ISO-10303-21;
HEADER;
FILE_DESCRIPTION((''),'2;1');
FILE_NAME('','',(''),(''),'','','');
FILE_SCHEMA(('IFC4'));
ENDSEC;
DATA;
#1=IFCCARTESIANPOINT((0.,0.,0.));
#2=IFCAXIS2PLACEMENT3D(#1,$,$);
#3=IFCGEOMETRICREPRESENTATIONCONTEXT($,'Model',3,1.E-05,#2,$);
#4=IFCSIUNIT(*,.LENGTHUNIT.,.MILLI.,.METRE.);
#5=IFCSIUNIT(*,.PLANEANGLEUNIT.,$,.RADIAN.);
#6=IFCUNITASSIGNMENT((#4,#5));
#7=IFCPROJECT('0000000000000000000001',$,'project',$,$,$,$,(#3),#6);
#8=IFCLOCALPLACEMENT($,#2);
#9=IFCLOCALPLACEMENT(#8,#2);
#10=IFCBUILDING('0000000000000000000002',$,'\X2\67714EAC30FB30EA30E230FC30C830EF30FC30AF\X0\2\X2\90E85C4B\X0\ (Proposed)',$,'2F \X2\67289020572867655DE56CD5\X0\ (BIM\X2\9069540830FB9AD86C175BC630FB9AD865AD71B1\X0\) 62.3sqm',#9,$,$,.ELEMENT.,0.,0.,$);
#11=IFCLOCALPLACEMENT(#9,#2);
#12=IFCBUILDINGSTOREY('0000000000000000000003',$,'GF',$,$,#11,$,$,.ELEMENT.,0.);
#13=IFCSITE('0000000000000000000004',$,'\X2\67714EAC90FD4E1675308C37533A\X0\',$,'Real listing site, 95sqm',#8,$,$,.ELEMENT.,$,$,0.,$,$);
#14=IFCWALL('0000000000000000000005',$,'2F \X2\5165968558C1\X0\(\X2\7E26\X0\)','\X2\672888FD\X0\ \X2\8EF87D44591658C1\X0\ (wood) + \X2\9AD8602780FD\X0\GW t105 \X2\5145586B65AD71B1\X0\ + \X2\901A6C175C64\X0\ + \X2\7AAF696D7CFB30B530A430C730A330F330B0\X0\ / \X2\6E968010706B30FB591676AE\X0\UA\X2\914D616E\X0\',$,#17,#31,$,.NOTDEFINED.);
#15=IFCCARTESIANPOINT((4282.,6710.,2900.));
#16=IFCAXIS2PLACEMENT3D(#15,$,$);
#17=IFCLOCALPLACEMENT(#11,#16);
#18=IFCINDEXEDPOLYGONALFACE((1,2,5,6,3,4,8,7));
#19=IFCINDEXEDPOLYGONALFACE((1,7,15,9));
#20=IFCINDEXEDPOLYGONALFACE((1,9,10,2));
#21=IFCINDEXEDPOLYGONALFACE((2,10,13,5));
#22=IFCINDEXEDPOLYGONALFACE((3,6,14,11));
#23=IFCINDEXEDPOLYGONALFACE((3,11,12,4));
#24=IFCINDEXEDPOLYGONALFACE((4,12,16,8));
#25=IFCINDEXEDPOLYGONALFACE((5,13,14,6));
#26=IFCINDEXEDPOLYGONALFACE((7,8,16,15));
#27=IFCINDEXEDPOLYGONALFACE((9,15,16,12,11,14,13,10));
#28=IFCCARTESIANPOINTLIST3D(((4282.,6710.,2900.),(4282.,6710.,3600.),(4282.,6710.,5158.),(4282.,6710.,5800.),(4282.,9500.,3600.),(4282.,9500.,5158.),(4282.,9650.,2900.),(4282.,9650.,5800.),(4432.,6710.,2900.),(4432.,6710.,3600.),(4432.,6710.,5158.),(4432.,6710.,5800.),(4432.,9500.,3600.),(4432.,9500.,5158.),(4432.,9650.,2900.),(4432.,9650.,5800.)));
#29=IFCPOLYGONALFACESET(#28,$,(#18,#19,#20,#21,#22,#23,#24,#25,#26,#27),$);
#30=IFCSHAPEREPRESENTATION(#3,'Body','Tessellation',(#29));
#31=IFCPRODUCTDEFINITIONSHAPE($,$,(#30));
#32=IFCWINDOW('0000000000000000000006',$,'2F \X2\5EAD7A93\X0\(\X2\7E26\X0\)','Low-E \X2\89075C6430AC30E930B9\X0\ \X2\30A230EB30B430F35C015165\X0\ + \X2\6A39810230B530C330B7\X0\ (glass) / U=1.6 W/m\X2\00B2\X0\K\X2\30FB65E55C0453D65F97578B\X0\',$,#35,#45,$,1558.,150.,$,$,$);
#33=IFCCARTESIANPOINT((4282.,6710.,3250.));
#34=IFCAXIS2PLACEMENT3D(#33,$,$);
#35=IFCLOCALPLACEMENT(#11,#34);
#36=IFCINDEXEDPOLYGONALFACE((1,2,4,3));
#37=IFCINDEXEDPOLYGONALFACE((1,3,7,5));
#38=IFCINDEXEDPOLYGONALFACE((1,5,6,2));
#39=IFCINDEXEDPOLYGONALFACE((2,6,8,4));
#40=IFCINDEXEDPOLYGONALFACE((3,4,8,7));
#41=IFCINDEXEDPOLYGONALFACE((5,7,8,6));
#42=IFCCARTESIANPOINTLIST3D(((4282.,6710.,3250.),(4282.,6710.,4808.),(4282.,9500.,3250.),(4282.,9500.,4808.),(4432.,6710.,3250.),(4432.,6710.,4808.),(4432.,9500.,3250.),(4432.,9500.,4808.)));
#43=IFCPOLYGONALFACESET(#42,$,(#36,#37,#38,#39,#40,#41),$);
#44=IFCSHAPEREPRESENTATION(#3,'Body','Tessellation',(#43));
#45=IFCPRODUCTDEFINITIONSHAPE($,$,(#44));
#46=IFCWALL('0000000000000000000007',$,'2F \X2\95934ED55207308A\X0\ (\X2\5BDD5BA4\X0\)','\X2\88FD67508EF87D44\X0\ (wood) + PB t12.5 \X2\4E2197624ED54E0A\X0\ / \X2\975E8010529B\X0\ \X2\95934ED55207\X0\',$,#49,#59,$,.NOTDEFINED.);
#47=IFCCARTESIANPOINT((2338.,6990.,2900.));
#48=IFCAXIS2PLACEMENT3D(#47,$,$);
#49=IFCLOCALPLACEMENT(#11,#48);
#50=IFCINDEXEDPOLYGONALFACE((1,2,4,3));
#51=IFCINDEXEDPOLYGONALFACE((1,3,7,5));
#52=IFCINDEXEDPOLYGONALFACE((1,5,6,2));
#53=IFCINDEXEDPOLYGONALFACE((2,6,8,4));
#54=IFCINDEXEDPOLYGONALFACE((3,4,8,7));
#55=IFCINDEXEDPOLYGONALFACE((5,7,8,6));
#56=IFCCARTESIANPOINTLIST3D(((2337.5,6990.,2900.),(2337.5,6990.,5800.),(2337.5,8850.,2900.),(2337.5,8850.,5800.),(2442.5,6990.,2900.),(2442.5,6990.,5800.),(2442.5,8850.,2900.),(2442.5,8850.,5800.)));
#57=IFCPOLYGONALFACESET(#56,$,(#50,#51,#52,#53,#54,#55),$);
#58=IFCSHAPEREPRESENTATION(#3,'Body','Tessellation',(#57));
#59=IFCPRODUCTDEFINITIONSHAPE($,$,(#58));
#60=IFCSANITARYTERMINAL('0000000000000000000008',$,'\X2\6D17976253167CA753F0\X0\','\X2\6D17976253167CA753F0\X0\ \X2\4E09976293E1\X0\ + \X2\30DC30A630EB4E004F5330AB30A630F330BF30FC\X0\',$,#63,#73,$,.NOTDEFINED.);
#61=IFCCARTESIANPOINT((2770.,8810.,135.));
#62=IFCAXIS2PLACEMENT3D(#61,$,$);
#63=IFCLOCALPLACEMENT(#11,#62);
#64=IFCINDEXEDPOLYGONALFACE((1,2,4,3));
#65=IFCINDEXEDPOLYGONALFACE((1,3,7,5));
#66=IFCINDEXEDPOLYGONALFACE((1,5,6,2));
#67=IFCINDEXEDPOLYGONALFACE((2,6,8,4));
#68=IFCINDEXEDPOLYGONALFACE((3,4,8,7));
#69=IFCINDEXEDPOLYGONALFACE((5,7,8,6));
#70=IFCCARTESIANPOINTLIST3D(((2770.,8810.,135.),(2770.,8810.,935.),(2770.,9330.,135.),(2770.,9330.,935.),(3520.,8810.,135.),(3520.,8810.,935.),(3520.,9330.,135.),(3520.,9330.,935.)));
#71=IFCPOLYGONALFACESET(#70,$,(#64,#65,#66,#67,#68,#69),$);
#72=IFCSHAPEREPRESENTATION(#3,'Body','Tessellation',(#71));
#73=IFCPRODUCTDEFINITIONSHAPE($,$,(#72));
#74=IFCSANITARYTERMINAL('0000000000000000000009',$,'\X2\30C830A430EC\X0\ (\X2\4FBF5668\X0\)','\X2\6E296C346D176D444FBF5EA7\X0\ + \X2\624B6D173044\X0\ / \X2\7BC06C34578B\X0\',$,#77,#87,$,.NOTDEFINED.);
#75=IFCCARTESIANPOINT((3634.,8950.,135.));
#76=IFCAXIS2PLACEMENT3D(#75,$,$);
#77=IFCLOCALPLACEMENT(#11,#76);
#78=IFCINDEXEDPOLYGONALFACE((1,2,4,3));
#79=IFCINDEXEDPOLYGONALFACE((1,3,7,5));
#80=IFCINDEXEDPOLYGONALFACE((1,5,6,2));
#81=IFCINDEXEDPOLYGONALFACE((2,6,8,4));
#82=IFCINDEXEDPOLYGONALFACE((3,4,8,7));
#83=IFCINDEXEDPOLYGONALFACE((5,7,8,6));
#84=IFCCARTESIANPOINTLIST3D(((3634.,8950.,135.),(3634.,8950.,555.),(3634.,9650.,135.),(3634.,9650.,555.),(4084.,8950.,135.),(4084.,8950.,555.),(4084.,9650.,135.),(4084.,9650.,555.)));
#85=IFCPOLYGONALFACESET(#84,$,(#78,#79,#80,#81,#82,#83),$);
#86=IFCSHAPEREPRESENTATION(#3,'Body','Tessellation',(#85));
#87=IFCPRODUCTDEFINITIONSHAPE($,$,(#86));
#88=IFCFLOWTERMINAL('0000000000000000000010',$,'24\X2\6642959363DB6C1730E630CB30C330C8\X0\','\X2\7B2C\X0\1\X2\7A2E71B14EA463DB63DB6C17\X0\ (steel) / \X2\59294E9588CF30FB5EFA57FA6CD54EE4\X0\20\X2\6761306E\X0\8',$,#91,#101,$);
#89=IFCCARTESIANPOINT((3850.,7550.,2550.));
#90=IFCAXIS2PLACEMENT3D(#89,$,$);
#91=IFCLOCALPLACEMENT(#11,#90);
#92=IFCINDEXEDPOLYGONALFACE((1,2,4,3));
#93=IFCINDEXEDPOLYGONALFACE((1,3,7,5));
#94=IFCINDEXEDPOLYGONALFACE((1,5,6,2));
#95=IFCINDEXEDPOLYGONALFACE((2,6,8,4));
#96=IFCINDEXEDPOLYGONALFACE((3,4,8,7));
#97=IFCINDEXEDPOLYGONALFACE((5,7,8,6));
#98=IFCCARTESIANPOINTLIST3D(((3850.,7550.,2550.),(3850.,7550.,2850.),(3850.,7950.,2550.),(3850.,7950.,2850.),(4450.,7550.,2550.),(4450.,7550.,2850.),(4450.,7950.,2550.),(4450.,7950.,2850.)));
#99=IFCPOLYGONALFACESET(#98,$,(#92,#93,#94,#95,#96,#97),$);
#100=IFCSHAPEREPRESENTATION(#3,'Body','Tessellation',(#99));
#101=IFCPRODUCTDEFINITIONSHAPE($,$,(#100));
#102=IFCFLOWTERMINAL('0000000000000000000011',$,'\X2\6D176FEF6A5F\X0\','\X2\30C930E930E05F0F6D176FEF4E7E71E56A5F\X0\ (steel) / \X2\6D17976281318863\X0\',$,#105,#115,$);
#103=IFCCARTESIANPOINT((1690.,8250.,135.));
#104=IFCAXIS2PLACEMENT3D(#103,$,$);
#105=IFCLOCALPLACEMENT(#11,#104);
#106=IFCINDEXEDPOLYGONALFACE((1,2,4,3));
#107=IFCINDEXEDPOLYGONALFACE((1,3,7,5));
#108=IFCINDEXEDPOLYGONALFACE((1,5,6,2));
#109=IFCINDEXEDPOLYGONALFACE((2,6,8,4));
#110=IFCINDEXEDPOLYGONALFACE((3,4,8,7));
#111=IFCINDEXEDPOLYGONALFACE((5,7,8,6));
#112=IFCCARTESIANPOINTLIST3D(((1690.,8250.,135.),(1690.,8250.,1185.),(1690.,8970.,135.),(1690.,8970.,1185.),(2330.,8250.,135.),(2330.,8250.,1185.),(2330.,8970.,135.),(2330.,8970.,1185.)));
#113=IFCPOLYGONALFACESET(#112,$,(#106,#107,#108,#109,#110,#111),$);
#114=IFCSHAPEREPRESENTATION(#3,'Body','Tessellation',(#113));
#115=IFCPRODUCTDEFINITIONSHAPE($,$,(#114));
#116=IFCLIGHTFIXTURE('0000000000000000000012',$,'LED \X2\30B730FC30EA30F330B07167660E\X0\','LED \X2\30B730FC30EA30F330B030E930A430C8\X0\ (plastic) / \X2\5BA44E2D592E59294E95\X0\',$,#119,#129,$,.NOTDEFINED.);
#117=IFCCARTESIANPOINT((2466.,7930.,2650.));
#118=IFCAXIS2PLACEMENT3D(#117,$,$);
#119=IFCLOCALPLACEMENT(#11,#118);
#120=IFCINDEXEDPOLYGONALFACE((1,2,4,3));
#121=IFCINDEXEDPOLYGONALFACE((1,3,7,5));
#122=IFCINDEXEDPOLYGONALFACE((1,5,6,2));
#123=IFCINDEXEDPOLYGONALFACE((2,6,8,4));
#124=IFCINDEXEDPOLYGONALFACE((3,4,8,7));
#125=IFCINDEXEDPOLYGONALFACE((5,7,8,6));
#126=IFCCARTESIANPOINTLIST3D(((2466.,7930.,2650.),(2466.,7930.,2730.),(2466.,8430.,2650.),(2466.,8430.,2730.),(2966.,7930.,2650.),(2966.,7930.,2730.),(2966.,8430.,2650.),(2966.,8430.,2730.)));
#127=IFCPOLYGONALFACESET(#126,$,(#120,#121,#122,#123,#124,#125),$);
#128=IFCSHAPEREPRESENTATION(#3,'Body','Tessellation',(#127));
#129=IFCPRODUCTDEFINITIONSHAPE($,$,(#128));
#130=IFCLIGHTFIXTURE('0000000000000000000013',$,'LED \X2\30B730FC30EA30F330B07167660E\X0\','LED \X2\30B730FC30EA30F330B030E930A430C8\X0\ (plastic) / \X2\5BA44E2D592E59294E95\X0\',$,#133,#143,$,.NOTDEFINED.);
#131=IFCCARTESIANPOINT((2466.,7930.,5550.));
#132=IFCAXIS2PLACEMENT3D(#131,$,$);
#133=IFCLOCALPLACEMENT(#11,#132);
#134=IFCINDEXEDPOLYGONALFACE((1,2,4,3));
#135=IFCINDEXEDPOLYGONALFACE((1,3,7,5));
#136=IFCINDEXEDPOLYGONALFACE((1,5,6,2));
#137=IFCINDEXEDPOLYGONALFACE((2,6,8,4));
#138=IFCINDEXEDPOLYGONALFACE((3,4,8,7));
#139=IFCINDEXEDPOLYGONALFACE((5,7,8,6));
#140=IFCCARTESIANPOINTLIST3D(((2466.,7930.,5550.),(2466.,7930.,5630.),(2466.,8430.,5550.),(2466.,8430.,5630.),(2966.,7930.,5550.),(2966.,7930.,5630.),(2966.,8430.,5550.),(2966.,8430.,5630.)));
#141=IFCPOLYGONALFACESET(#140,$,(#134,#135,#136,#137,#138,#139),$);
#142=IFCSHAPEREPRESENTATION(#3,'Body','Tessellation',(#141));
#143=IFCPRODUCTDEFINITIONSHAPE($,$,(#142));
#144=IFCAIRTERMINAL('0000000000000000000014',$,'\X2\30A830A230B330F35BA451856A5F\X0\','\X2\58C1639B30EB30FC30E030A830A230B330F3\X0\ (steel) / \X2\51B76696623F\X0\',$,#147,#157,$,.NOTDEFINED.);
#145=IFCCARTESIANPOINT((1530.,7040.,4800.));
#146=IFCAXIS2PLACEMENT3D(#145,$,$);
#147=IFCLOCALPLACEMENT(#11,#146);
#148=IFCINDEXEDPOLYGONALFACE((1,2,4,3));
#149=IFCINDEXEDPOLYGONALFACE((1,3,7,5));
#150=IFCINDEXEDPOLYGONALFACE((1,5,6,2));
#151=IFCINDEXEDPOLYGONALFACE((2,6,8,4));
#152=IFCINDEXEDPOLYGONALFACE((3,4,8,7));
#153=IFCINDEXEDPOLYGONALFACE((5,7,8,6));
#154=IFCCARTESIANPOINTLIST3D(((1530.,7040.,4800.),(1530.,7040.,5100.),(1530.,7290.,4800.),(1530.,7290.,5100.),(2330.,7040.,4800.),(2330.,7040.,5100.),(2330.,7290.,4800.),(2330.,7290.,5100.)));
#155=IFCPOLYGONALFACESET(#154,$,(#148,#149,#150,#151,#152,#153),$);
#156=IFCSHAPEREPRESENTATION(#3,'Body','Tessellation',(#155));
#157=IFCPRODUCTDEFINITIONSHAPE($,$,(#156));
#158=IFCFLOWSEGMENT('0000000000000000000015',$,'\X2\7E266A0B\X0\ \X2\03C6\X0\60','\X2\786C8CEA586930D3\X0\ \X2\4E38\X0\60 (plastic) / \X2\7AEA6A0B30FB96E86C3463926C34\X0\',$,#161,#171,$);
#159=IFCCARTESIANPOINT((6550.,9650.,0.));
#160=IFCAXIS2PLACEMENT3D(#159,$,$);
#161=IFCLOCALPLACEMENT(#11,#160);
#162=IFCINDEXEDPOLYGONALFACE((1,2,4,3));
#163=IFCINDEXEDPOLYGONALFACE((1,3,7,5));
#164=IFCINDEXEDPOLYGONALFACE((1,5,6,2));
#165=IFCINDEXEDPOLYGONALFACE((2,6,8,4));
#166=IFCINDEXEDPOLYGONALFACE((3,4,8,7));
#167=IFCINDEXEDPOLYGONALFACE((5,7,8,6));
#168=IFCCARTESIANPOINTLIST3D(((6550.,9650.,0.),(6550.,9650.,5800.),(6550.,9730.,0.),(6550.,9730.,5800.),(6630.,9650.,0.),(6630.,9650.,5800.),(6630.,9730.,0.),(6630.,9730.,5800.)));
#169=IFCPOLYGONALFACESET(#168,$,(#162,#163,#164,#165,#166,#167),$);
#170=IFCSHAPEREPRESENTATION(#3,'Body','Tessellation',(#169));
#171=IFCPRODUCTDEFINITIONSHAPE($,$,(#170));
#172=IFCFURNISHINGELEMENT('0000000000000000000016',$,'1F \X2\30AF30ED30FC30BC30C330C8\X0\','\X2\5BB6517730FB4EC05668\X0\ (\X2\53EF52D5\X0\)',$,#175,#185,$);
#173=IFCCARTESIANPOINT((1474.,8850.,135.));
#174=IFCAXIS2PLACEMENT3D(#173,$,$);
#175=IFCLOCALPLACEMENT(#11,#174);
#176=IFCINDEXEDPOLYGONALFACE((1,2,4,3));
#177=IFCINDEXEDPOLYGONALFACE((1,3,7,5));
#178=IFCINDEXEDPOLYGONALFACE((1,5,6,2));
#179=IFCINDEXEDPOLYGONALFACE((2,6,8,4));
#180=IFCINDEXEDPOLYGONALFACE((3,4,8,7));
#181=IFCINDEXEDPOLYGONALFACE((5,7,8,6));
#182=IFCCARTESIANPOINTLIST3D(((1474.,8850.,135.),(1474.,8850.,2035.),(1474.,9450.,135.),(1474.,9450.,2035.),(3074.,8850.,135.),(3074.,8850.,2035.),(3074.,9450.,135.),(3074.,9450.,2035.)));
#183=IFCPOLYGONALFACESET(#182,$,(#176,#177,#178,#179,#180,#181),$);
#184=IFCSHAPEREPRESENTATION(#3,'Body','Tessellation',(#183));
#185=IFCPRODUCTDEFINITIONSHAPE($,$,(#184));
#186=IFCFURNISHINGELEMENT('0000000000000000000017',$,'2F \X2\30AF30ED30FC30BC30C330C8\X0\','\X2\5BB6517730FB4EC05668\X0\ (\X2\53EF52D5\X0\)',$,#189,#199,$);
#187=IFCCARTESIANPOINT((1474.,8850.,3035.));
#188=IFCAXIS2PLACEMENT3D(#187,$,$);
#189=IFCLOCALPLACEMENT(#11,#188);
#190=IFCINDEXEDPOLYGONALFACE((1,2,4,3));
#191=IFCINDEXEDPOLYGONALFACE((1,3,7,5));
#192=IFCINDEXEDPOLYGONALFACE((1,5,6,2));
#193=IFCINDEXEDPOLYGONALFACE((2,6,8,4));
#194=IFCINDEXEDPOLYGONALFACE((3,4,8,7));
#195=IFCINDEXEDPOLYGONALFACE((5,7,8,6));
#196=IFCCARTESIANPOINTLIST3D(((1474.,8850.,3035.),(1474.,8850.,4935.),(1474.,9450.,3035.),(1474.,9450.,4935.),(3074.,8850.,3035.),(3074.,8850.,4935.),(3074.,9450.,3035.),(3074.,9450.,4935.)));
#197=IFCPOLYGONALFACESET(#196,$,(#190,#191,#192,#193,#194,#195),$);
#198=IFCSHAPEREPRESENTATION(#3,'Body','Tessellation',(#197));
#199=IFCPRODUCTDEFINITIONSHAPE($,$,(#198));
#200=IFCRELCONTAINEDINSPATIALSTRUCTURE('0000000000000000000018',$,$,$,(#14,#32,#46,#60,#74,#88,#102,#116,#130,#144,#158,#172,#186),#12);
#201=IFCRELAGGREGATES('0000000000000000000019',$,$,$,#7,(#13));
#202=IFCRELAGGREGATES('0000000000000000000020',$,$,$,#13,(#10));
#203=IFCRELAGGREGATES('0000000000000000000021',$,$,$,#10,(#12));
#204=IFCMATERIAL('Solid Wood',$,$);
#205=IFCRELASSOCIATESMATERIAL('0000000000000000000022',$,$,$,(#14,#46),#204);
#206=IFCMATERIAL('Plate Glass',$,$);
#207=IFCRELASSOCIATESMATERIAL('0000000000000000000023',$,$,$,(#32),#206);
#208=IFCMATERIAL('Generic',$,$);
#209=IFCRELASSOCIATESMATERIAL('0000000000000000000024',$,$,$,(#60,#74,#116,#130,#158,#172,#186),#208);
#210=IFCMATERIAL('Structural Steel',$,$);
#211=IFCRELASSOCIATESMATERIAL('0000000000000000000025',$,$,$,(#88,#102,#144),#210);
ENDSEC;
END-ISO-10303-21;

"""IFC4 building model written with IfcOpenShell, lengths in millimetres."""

from ifc_helpers import new_model, si_unit, frame, frame_2d, origin, place, context, project, spatial, rectangle, extrude, material, element, fill, save


model = new_model("IFC4")

# Units and contexts
model_context = context("Model", 3, precision=1e-05, world=origin())
ifc_project = project(units=[si_unit("LENGTHUNIT", "METRE", prefix="MILLI"), si_unit("PLANEANGLEUNIT", "RADIAN")], contexts=[model_context])

# Site, building, storey
site_placement = place(None, origin())
site = spatial("IfcSite", under=ifc_project, at=site_placement, Name="東京都世田谷区", ObjectType="Real listing site, 95sqm", CompositionType="ELEMENT", RefElevation=0.0)
building_placement = place(site_placement, origin())
building = spatial("IfcBuilding", under=site, at=building_placement, Name="東京・リモートワーク2部屋 (Proposed)", ObjectType="2F 木造在来工法 (BIM適合・高気密・高断熱) 62.3sqm", CompositionType="ELEMENT", ElevationOfRefHeight=0.0, ElevationOfTerrain=0.0)
storey_placement = place(building_placement, origin())
storey = spatial("IfcBuildingStorey", under=building, at=storey_placement, Name="GF", CompositionType="ELEMENT", Elevation=0.0)

# Shared definitions
ifc_material_1 = material(Name="Solid Wood")

# Shared definitions
ifc_material_2 = material(Name="Plate Glass")

# Wall, opening, window
wall_1_placement = place(storey_placement, frame((4282.0, 6710.0, 2900.0)))
wall_1 = element("IfcWall", 1, at=wall_1_placement, inside=storey, material=ifc_material_1, Name="2F 入隅壁(縦)", Description="木製 軸組外壁 (wood) + 高性能GW t105 充填断熱 + 通気層 + 窯業系サイディング / 準耐火・外皮UA配慮", PredefinedType="NOTDEFINED", context=model_context, shape_type="SweptSolid", body=[
    extrude(rectangle(XDim=150.0, YDim=2940.0, at=frame_2d((75.0, 1470.0))), frame((4282.0, 6710.0, 2900.0)), (0.0, 0.0, 1.0), 2900.0),
])
opening_1_placement = place(storey_placement, frame((4282.0, 6710.0, 3250.0)))
opening_1 = element("IfcOpeningElement", 2, at=opening_1_placement, cuts=wall_1, PredefinedType="NOTDEFINED", context=model_context, shape_type="SweptSolid", body=[
    extrude(rectangle(XDim=150.0, YDim=2790.0, at=frame_2d((75.0, 1395.0))), frame((4282.0, 6710.0, 3250.0)), (0.0, 0.0, 1.0), 1558.0),
])
window_1_placement = place(storey_placement, frame((4282.0, 6710.0, 3250.0)))
window_1 = element("IfcWindow", 3, at=window_1_placement, inside=storey, material=ifc_material_2, Name="2F 庭窓(縦)", Description="Low-E 複層ガラス アルゴン封入 + 樹脂サッシ (glass) / U=1.6 W/m²K・日射取得型", OverallHeight=1558.0, OverallWidth=150.0, context=model_context, shape_type="SweptSolid", body=[
    extrude(rectangle(XDim=150.0, YDim=2790.0, at=frame_2d((75.0, 1395.0))), frame((4282.0, 6710.0, 3250.0)), (0.0, 0.0, 1.0), 1558.0),
])
fill(opening_1, window_1)

# Wall
wall_2_placement = place(storey_placement, frame((2338.0, 6990.0, 2900.0)))
element("IfcWall", 4, at=wall_2_placement, inside=storey, material=ifc_material_1, Name="2F 間仕切り (寝室)", Description="製材軸組 (wood) + PB t12.5 両面仕上 / 非耐力 間仕切", PredefinedType="NOTDEFINED", context=model_context, shape_type="SweptSolid", body=[
    extrude(rectangle(XDim=105.0, YDim=1860.0, at=frame_2d((52.0, 930.0))), frame((2338.0, 6990.0, 2900.0)), (0.0, 0.0, 1.0), 2900.0),
])

# Sanitary terminals
ifc_material_3 = material(Name="Generic")
sanitary_terminal_1_placement = place(storey_placement, frame((2770.0, 8810.0, 135.0)))
element("IfcSanitaryTerminal", 5, at=sanitary_terminal_1_placement, inside=storey, material=ifc_material_3, Name="洗面化粧台", Description="洗面化粧台 三面鏡 + ボウル一体カウンター", PredefinedType="NOTDEFINED", context=model_context, shape_type="SweptSolid", body=[
    extrude(rectangle(XDim=750.0, YDim=520.0, at=frame_2d((375.0, 260.0))), frame((2770.0, 8810.0, 135.0)), (0.0, 0.0, 1.0), 800.0),
])
sanitary_terminal_2_placement = place(storey_placement, frame((3634.0, 8950.0, 135.0)))
element("IfcSanitaryTerminal", 6, at=sanitary_terminal_2_placement, inside=storey, material=ifc_material_3, Name="トイレ (便器)", Description="温水洗浄便座 + 手洗い / 節水型", PredefinedType="NOTDEFINED", context=model_context, shape_type="SweptSolid", body=[
    extrude(rectangle(XDim=450.0, YDim=700.0, at=frame_2d((225.0, 350.0))), frame((3634.0, 8950.0, 135.0)), (0.0, 0.0, 1.0), 420.0),
])

# Flow terminals
ifc_material_4 = material(Name="Structural Steel")
flow_terminal_1_placement = place(storey_placement, frame((3850.0, 7550.0, 2550.0)))
element("IfcFlowTerminal", 7, at=flow_terminal_1_placement, inside=storey, material=ifc_material_4, Name="24時間換気ユニット", Description="第1種熱交換換気 (steel) / 天井裏・建基法令20条の8", context=model_context, shape_type="SweptSolid", body=[
    extrude(rectangle(XDim=600.0, YDim=400.0, at=frame_2d((300.0, 200.0))), frame((3850.0, 7550.0, 2550.0)), (0.0, 0.0, 1.0), 300.0),
])
flow_terminal_2_placement = place(storey_placement, frame((1690.0, 8250.0, 135.0)))
element("IfcFlowTerminal", 8, at=flow_terminal_2_placement, inside=storey, material=ifc_material_4, Name="洗濯機", Description="ドラム式洗濯乾燥機 (steel) / 洗面脱衣", context=model_context, shape_type="SweptSolid", body=[
    extrude(rectangle(XDim=640.0, YDim=720.0, at=frame_2d((320.0, 360.0))), frame((1690.0, 8250.0, 135.0)), (0.0, 0.0, 1.0), 1050.0),
])

# Light fixtures
light_fixture_1_placement = place(storey_placement, frame((2466.0, 7930.0, 2650.0)))
element("IfcLightFixture", 9, at=light_fixture_1_placement, inside=storey, material=ifc_material_3, Name="LED シーリング照明", Description="LED シーリングライト (plastic) / 室中央天井", PredefinedType="NOTDEFINED", context=model_context, shape_type="SweptSolid", body=[
    extrude(rectangle(XDim=500.0, YDim=500.0, at=frame_2d((250.0, 250.0))), frame((2466.0, 7930.0, 2650.0)), (0.0, 0.0, 1.0), 80.0),
])
light_fixture_2_placement = place(storey_placement, frame((2466.0, 7930.0, 5550.0)))
element("IfcLightFixture", 10, at=light_fixture_2_placement, inside=storey, material=ifc_material_3, Name="LED シーリング照明", Description="LED シーリングライト (plastic) / 室中央天井", PredefinedType="NOTDEFINED", context=model_context, shape_type="SweptSolid", body=[
    extrude(rectangle(XDim=500.0, YDim=500.0, at=frame_2d((250.0, 250.0))), frame((2466.0, 7930.0, 5550.0)), (0.0, 0.0, 1.0), 80.0),
])

# Air terminal
air_terminal_placement = place(storey_placement, frame((1530.0, 7040.0, 4800.0)))
element("IfcAirTerminal", 11, at=air_terminal_placement, inside=storey, material=ifc_material_4, Name="エアコン室内機", Description="壁掛ルームエアコン (steel) / 冷暖房", PredefinedType="NOTDEFINED", context=model_context, shape_type="SweptSolid", body=[
    extrude(rectangle(XDim=800.0, YDim=250.0, at=frame_2d((400.0, 125.0))), frame((1530.0, 7040.0, 4800.0)), (0.0, 0.0, 1.0), 300.0),
])

# Flow segment
flow_segment_placement = place(storey_placement, frame((6550.0, 9650.0, 0.0)))
element("IfcFlowSegment", 12, at=flow_segment_placement, inside=storey, material=ifc_material_3, Name="縦樋 φ60", Description="硬質塩ビ 丸60 (plastic) / 竪樋・雨水排水", context=model_context, shape_type="SweptSolid", body=[
    extrude(rectangle(XDim=80.0, YDim=80.0, at=frame_2d((40.0, 40.0))), frame((6550.0, 9650.0, 0.0)), (0.0, 0.0, 1.0), 5800.0),
])

# Furnishing elements
furnishing_1_placement = place(storey_placement, frame((1474.0, 8850.0, 135.0)))
element("IfcFurnishingElement", 13, at=furnishing_1_placement, inside=storey, material=ifc_material_3, Name="1F クローゼット", Description="家具・什器 (可動)", context=model_context, shape_type="SweptSolid", body=[
    extrude(rectangle(XDim=1600.0, YDim=600.0, at=frame_2d((800.0, 300.0))), frame((1474.0, 8850.0, 135.0)), (0.0, 0.0, 1.0), 1900.0),
])
furnishing_2_placement = place(storey_placement, frame((1474.0, 8850.0, 3035.0)))
element("IfcFurnishingElement", 14, at=furnishing_2_placement, inside=storey, material=ifc_material_3, Name="2F クローゼット", Description="家具・什器 (可動)", context=model_context, shape_type="SweptSolid", body=[
    extrude(rectangle(XDim=1600.0, YDim=600.0, at=frame_2d((800.0, 300.0))), frame((1474.0, 8850.0, 3035.0)), (0.0, 0.0, 1.0), 1900.0),
])

save(model, "model.ifc")
